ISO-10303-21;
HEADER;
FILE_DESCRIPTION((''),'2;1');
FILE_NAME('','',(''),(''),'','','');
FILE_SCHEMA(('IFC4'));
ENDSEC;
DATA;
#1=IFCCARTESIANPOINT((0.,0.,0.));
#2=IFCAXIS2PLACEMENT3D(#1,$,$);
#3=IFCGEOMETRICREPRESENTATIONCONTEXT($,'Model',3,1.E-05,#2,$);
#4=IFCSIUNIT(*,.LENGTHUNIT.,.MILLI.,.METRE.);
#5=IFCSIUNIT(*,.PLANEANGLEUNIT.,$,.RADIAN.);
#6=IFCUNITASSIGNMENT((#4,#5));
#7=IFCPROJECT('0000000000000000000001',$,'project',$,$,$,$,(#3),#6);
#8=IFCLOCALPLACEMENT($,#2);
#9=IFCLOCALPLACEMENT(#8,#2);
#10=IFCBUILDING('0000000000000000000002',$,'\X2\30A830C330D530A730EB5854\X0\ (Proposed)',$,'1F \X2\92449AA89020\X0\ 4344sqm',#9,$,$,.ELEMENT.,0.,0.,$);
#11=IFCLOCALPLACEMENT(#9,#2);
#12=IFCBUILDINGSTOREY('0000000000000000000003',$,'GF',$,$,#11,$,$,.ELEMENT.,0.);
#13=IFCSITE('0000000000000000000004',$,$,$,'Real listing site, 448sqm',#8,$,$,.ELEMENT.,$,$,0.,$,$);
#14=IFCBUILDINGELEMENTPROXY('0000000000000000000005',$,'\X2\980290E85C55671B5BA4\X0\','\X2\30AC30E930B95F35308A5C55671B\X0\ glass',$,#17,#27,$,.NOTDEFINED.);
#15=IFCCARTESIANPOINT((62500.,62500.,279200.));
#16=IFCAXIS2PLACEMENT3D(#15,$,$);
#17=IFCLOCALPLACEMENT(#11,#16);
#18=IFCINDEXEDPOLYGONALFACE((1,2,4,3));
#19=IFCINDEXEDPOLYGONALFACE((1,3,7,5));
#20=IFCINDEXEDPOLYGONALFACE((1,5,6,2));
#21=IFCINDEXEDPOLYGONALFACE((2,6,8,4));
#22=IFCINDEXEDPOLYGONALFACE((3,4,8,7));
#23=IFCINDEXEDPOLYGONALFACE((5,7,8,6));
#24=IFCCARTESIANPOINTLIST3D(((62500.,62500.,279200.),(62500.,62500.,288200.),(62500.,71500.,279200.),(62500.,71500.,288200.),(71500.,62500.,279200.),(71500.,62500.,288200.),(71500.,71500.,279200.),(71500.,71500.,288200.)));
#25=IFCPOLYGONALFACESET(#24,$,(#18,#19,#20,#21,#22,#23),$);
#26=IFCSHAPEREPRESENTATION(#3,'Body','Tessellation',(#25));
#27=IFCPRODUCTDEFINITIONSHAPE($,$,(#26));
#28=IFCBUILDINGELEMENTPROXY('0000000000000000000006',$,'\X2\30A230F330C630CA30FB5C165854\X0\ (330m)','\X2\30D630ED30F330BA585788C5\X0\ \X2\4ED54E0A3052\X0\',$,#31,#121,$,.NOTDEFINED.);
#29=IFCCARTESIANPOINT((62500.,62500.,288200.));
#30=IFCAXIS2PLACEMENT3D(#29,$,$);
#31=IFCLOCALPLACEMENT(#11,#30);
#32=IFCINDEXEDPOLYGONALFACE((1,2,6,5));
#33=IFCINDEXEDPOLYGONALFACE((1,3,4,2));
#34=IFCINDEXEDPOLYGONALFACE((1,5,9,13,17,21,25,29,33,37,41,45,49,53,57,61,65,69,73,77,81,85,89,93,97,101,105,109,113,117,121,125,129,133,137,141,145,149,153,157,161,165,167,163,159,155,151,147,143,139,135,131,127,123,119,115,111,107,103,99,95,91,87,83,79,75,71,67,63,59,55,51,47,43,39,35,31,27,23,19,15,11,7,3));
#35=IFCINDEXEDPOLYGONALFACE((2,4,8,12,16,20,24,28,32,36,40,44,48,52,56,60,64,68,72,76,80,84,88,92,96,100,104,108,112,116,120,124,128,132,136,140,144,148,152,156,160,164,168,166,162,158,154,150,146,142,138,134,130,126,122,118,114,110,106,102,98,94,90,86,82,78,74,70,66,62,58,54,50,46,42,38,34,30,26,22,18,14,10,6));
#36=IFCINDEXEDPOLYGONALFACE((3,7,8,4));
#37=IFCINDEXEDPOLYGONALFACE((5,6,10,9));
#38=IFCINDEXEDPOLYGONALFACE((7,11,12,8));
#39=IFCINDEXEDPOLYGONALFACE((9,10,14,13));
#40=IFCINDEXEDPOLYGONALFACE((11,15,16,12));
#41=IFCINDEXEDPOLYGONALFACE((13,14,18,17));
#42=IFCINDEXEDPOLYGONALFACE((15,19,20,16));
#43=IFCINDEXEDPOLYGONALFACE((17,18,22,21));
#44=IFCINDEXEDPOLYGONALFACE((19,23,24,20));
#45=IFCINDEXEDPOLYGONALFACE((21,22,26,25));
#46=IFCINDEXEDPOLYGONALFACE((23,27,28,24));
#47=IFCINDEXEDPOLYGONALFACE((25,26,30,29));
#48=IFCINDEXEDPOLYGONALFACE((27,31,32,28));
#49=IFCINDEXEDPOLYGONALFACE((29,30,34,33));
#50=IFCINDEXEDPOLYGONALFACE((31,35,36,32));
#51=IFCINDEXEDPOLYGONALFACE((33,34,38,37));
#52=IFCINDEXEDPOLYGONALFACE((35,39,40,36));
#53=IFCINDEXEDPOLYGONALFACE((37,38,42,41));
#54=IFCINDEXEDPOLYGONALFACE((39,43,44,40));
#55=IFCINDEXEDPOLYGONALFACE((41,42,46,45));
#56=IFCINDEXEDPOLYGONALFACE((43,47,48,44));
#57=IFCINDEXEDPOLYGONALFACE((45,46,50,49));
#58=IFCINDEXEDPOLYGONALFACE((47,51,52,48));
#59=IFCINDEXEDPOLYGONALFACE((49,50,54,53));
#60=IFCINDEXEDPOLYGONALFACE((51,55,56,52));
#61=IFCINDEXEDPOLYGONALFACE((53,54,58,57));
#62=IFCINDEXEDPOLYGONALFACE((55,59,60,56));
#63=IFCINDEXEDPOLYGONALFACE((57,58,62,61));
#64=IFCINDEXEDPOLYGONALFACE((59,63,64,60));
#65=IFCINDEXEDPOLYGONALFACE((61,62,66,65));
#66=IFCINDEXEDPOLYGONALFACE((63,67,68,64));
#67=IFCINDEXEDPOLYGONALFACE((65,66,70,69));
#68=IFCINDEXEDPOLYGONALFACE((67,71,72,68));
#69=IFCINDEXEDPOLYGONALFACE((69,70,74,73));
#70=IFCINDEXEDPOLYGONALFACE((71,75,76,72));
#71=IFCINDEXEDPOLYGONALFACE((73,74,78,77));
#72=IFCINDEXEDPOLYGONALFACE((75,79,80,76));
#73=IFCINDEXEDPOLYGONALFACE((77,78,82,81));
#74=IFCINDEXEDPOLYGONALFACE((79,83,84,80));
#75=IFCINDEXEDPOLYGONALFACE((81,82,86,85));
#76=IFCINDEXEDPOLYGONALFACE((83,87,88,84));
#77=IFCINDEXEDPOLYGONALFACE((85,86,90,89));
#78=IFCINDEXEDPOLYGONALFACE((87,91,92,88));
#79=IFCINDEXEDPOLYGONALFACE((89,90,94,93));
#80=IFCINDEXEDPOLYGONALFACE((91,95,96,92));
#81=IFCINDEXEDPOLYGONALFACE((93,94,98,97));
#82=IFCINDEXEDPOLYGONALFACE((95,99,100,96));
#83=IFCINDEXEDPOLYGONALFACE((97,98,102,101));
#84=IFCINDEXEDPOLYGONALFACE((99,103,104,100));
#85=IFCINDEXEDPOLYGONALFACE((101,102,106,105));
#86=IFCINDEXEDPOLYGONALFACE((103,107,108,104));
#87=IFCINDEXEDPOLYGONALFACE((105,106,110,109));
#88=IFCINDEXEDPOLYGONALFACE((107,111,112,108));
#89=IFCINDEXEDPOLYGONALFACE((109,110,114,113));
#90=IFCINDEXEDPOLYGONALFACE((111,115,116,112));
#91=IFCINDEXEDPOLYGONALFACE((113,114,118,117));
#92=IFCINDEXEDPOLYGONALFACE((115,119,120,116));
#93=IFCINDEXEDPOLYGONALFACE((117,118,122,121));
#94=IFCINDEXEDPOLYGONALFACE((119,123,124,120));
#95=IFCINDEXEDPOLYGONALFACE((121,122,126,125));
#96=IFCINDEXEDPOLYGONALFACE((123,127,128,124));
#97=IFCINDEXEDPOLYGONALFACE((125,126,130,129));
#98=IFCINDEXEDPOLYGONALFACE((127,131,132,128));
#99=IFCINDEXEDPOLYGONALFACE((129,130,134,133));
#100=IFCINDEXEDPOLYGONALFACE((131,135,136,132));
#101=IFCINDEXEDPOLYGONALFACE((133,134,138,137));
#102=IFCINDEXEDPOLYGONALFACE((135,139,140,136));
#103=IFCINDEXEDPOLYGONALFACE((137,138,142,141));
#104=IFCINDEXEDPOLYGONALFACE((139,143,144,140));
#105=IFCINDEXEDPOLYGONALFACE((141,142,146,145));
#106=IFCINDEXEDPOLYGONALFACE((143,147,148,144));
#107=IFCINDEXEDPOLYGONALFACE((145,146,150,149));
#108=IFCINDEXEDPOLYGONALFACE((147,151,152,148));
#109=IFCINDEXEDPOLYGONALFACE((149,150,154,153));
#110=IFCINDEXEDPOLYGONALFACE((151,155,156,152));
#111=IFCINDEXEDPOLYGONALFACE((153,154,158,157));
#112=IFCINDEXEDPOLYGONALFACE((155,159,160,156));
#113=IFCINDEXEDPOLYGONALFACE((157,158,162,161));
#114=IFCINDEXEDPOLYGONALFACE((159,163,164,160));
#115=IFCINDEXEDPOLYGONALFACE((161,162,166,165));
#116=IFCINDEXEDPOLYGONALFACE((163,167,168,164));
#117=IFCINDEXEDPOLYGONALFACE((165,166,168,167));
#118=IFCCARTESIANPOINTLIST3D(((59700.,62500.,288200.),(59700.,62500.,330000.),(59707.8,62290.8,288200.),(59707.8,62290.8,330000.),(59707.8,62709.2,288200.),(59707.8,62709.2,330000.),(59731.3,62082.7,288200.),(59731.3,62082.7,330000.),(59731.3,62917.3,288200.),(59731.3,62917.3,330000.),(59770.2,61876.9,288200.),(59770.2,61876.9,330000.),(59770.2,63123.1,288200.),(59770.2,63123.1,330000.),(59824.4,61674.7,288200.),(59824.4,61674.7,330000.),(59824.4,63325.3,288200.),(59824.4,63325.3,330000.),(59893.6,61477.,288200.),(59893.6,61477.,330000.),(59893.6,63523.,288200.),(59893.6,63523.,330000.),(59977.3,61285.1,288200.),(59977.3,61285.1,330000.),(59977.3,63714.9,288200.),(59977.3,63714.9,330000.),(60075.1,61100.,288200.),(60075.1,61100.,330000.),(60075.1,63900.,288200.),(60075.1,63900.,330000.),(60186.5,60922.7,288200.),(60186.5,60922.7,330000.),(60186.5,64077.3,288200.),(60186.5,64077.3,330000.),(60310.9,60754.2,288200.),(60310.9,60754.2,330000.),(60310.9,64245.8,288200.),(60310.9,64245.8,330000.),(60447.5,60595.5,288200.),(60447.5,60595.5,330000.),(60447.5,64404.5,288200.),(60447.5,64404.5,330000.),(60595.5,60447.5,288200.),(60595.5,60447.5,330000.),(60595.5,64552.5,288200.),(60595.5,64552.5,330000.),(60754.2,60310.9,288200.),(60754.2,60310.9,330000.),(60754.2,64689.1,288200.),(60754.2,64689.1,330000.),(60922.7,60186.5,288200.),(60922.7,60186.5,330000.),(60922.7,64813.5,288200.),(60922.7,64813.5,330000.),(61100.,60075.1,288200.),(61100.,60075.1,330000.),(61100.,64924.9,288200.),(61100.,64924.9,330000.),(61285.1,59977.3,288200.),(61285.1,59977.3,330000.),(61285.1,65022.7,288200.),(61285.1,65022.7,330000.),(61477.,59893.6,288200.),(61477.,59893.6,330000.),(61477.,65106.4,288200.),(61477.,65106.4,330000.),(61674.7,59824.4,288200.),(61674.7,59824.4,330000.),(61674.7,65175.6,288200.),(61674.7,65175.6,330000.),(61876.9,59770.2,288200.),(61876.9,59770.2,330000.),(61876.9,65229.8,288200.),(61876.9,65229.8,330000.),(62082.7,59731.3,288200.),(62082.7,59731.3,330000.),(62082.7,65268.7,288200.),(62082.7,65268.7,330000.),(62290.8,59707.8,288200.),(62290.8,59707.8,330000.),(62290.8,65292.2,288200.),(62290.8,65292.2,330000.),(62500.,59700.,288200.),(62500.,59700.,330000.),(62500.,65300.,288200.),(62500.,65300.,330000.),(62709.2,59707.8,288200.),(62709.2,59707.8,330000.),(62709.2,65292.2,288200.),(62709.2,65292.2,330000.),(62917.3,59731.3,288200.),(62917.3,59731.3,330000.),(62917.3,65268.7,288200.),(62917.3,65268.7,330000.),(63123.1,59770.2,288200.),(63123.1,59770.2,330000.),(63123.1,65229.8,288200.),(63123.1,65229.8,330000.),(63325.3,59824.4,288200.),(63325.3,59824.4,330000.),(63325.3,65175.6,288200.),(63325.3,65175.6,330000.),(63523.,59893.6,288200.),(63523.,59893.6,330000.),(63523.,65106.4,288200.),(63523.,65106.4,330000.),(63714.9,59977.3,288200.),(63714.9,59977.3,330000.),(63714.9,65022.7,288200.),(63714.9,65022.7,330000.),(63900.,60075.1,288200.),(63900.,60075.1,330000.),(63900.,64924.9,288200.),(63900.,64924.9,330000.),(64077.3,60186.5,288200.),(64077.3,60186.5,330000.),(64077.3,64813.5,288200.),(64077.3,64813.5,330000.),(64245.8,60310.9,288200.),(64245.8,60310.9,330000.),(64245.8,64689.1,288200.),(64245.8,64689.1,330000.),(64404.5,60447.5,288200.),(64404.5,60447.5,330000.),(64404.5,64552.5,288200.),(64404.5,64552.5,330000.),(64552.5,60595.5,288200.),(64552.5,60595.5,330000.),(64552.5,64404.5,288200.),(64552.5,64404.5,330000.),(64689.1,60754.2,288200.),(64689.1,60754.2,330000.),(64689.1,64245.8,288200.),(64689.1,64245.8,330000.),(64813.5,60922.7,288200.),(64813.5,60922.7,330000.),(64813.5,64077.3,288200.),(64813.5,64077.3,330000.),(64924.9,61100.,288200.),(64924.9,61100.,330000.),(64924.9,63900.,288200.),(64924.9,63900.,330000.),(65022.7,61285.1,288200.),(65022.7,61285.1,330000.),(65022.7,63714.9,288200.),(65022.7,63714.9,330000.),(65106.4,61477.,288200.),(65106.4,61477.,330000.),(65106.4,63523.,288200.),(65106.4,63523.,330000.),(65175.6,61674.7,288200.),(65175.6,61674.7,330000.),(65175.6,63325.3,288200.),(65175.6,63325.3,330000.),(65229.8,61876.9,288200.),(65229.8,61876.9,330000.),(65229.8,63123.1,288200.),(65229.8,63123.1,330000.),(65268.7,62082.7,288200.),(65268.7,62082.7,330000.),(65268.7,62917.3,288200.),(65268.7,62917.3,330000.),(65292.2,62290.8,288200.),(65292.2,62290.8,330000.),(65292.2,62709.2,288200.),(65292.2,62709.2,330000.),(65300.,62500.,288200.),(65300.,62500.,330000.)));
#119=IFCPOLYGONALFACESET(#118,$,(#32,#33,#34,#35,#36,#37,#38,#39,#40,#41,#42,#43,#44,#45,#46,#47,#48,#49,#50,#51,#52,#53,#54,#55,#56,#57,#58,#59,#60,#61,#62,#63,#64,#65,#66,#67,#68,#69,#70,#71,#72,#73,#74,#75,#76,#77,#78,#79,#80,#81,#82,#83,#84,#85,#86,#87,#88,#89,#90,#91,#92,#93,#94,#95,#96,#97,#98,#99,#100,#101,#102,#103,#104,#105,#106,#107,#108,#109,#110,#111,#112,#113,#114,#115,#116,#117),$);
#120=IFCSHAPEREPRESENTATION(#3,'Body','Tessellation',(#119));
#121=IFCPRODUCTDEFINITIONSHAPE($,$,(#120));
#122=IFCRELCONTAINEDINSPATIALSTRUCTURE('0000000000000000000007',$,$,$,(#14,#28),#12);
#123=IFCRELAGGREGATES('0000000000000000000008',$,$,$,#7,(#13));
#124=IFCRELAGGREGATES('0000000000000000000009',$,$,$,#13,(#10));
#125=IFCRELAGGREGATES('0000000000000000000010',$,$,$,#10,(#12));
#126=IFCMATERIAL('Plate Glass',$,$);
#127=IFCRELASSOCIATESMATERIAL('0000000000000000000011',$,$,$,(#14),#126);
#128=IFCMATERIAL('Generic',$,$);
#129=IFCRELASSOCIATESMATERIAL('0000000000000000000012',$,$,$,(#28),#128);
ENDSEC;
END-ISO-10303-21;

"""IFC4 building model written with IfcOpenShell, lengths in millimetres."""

from ifc_helpers import new_model, si_unit, frame, frame_2d, origin, origin_2d, place, context, project, spatial, rectangle, circle, extrude, material, element, save


model = new_model("IFC4")

# Units and contexts
model_context = context("Model", 3, precision=1e-05, world=origin())
ifc_project = project(units=[si_unit("LENGTHUNIT", "METRE", prefix="MILLI"), si_unit("PLANEANGLEUNIT", "RADIAN")], contexts=[model_context])

# Site, building, storey
site_placement = place(None, origin())
site = spatial("IfcSite", under=ifc_project, at=site_placement, ObjectType="Real listing site, 448sqm", CompositionType="ELEMENT", RefElevation=0.0)
building_placement = place(site_placement, origin())
building = spatial("IfcBuilding", under=site, at=building_placement, Name="エッフェル塔 (Proposed)", ObjectType="1F 鉄骨造 4344sqm", CompositionType="ELEMENT", ElevationOfRefHeight=0.0, ElevationOfTerrain=0.0)
storey_placement = place(building_placement, origin())
storey = spatial("IfcBuildingStorey", under=building, at=storey_placement, Name="GF", CompositionType="ELEMENT", Elevation=0.0)

# Shared definitions
ifc_material_1 = material(Name="Generic")

# Building element proxies
ifc_material_2 = material(Name="Plate Glass")
proxy_1_placement = place(storey_placement, frame((62500.0, 62500.0, 279200.0)))
element("IfcBuildingElementProxy", 1, at=proxy_1_placement, inside=storey, material=ifc_material_2, Name="頂部展望室", Description="ガラス張り展望 glass", PredefinedType="NOTDEFINED", context=model_context, shape_type="SweptSolid", body=[
    extrude(rectangle(XDim=9000.0, YDim=9000.0, at=frame_2d((4500.0, 4500.0))), frame((62500.0, 62500.0, 279200.0)), (0.0, 0.0, 1.0), 9000.0),
])
proxy_2_placement = place(storey_placement, frame((62500.0, 62500.0, 288200.0)))
element("IfcBuildingElementProxy", 2, at=proxy_2_placement, inside=storey, material=ifc_material_1, Name="アンテナ・尖塔 (330m)", Description="ブロンズ塗装 仕上げ", PredefinedType="NOTDEFINED", context=model_context, shape_type="SweptSolid", body=[
    extrude(circle(Radius=2800.0, at=origin_2d()), frame((62500.0, 62500.0, 288200.0)), (0.0, 0.0, 1.0), 41800.0),
])

save(model, "model.ifc")
